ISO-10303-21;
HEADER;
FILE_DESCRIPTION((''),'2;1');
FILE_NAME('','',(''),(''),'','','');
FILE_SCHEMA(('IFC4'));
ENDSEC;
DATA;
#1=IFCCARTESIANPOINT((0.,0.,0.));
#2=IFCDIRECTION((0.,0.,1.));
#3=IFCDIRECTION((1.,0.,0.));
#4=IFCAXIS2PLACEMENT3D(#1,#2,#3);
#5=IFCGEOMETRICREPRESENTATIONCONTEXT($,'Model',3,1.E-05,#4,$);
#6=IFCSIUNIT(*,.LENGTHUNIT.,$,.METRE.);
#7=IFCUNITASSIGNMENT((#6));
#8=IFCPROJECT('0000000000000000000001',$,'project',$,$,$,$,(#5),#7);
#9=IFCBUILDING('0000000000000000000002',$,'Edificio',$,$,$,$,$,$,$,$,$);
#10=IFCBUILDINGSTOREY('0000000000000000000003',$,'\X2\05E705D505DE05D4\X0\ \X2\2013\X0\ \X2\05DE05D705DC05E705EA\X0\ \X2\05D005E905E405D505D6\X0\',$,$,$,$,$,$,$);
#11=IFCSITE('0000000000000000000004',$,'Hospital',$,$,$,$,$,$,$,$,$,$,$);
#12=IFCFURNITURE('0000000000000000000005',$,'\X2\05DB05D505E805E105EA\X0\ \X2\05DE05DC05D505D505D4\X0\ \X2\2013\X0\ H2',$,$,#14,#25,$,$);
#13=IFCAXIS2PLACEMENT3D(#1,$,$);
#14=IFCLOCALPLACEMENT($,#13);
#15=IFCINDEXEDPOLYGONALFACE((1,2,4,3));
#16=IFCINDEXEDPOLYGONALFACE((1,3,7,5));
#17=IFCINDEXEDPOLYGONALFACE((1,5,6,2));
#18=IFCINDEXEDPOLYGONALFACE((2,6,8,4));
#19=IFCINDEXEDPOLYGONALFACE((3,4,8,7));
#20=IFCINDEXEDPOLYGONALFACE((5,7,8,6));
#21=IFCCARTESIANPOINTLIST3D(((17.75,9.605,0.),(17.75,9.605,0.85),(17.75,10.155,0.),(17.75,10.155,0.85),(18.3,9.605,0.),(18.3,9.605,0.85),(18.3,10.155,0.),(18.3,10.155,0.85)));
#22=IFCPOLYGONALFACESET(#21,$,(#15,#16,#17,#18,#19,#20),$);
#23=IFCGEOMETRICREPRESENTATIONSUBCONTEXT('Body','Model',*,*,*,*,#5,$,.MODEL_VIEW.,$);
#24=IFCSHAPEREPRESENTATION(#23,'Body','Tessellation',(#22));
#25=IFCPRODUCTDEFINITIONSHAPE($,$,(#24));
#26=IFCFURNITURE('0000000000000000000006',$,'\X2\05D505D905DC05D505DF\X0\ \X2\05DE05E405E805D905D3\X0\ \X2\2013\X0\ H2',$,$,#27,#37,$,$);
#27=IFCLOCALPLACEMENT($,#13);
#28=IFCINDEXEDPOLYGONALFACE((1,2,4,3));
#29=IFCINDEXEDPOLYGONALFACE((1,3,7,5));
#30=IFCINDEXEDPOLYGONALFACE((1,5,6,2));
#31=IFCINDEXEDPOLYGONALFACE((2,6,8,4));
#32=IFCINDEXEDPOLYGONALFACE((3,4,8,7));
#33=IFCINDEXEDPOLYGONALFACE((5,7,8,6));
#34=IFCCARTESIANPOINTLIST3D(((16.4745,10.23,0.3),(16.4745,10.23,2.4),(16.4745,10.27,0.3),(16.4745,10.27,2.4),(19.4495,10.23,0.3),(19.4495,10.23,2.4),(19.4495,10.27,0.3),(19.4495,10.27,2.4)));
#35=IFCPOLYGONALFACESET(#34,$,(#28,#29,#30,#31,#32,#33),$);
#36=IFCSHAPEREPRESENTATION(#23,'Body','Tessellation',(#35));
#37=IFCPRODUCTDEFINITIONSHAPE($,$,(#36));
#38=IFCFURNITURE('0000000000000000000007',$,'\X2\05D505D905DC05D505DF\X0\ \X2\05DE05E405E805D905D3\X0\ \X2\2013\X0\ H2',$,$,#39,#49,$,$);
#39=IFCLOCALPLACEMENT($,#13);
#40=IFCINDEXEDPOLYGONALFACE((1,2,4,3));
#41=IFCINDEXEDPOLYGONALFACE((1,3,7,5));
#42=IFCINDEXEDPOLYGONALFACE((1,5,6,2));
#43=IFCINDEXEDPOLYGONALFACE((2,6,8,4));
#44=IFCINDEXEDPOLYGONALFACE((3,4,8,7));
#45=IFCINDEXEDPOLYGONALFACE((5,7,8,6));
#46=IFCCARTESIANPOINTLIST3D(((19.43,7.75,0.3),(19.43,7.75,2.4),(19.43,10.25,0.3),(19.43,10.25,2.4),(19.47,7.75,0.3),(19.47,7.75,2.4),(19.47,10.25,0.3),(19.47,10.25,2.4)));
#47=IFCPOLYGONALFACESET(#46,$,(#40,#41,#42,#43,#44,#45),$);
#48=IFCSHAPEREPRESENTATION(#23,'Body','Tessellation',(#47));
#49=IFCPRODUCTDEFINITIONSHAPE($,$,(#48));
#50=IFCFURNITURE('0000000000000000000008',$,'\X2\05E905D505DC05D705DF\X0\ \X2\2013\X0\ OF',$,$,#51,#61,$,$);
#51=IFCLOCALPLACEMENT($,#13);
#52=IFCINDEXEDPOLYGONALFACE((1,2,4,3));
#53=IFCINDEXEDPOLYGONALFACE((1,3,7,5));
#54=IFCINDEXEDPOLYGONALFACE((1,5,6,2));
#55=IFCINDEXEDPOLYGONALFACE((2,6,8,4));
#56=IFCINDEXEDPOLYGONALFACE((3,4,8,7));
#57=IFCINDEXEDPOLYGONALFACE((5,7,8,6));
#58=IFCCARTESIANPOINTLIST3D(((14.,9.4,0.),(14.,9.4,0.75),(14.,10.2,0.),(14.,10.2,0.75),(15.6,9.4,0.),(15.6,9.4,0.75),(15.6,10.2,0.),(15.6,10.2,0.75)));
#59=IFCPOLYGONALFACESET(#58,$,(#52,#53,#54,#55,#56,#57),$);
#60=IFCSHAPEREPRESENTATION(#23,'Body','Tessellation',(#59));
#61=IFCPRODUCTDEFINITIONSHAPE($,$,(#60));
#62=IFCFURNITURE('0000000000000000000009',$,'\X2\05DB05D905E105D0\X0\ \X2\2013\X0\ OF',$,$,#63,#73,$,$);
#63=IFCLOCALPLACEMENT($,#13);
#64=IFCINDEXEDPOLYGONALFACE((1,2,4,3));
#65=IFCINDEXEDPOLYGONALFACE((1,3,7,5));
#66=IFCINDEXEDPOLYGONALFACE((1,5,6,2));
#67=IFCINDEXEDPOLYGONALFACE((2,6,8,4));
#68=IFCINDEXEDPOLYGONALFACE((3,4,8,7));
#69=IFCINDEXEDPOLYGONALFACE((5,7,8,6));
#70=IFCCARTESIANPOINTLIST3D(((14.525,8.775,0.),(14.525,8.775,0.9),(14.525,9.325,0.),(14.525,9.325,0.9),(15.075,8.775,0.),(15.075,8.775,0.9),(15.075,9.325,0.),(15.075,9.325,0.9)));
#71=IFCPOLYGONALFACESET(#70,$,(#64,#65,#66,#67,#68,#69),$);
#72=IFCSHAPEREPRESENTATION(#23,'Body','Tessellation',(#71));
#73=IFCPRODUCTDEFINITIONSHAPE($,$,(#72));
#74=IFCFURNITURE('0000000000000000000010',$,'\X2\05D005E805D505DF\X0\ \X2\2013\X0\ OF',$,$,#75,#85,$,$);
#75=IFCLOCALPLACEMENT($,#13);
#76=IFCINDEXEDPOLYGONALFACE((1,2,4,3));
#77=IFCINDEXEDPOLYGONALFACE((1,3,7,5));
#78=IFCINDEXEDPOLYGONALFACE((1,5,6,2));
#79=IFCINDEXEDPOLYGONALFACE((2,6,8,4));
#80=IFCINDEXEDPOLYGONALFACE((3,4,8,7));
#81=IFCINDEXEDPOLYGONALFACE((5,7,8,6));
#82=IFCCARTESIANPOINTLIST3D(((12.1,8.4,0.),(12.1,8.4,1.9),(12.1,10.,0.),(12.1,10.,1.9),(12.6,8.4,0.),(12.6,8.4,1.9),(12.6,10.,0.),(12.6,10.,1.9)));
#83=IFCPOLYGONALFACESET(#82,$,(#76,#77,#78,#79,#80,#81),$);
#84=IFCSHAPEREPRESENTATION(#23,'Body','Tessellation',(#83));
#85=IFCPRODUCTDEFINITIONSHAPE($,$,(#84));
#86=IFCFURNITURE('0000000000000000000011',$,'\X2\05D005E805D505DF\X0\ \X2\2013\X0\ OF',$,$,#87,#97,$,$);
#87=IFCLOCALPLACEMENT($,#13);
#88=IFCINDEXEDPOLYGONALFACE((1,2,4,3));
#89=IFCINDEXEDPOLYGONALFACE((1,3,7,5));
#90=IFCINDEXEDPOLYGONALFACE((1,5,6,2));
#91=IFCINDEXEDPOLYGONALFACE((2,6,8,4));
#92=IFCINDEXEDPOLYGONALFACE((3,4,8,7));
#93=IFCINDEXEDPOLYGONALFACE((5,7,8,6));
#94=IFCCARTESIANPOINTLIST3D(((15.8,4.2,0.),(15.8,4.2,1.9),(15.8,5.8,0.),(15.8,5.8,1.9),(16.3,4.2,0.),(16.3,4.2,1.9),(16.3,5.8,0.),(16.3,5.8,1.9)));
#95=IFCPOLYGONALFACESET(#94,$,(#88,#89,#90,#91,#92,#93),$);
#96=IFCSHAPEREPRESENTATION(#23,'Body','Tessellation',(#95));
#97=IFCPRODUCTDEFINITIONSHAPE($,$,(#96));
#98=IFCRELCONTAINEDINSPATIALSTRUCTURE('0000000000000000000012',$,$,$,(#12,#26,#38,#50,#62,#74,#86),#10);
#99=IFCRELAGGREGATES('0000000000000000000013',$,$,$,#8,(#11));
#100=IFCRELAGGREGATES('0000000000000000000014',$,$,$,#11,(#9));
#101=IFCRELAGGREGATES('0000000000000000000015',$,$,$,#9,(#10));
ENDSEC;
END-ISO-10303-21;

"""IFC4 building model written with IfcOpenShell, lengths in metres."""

from ifc_helpers import new_model, si_unit, frame, origin_with_axes, context, subcontext, project, spatial, line, indexed_curve, outline, extrude, element, save


model = new_model("IFC4")

# Units and contexts
model_context = context("Model", 3, precision=1e-05, world=origin_with_axes())
body_context = subcontext(model_context, "Body", "Model", "MODEL_VIEW")
ifc_project = project(units=[si_unit("LENGTHUNIT", "METRE")], contexts=[model_context])

# Site, building, storey
site = spatial("IfcSite", under=ifc_project, Name="Hospital")
building = spatial("IfcBuilding", under=site, Name="Edificio")
storey = spatial("IfcBuildingStorey", under=building, Name="קומה – מחלקת אשפוז")

# Furniture
element("IfcFurniture", 1, inside=storey, Name="כורסת מלווה – H2", context=body_context, shape_type="SweptSolid", body=[
    extrude(outline(indexed_curve([(0.0, 0.0), (0.55, 0.0), (0.55, 0.55), (0.0, 0.55)], segments=[line(1, 2, 3, 4, 1)])), frame((17.75, 9.605, 0.0), z_axis=(0.0, 0.0, 1.0), x_axis=(1.0, 0.0, 0.0)), (0.0, 0.0, 1.0), 0.85),
])
element("IfcFurniture", 2, inside=storey, Name="וילון מפריד – H2", context=body_context, shape_type="SweptSolid", body=[
    extrude(outline(indexed_curve([(0.0, 0.0), (2.975, 0.0), (2.975, 0.04), (0.0, 0.04)], segments=[line(1, 2, 3, 4, 1)])), frame((16.4745, 10.23, 0.3), z_axis=(0.0, 0.0, 1.0), x_axis=(1.0, 0.0, 0.0)), (0.0, 0.0, 1.0), 2.1),
])
element("IfcFurniture", 3, inside=storey, Name="וילון מפריד – H2", context=body_context, shape_type="SweptSolid", body=[
    extrude(outline(indexed_curve([(0.0, 0.0), (0.04, 0.0), (0.04, 2.5), (0.0, 2.5)], segments=[line(1, 2, 3, 4, 1)])), frame((19.43, 7.75, 0.3), z_axis=(0.0, 0.0, 1.0), x_axis=(1.0, 0.0, 0.0)), (0.0, 0.0, 1.0), 2.1),
])
element("IfcFurniture", 4, inside=storey, Name="שולחן – OF", context=body_context, shape_type="SweptSolid", body=[
    extrude(outline(indexed_curve([(0.0, 0.0), (1.6, 0.0), (1.6, 0.8), (0.0, 0.8)], segments=[line(1, 2, 3, 4, 1)])), frame((14.0, 9.4, 0.0), z_axis=(0.0, 0.0, 1.0), x_axis=(1.0, 0.0, 0.0)), (0.0, 0.0, 1.0), 0.75),
])
element("IfcFurniture", 5, inside=storey, Name="כיסא – OF", context=body_context, shape_type="SweptSolid", body=[
    extrude(outline(indexed_curve([(0.0, 0.0), (0.55, 0.0), (0.55, 0.55), (0.0, 0.55)], segments=[line(1, 2, 3, 4, 1)])), frame((14.525, 8.775, 0.0), z_axis=(0.0, 0.0, 1.0), x_axis=(1.0, 0.0, 0.0)), (0.0, 0.0, 1.0), 0.9),
])
element("IfcFurniture", 6, inside=storey, Name="ארון – OF", context=body_context, shape_type="SweptSolid", body=[
    extrude(outline(indexed_curve([(0.0, 0.0), (0.5, 0.0), (0.5, 1.6), (0.0, 1.6)], segments=[line(1, 2, 3, 4, 1)])), frame((12.1, 8.4, 0.0), z_axis=(0.0, 0.0, 1.0), x_axis=(1.0, 0.0, 0.0)), (0.0, 0.0, 1.0), 1.9),
])
element("IfcFurniture", 7, inside=storey, Name="ארון – OF", context=body_context, shape_type="SweptSolid", body=[
    extrude(outline(indexed_curve([(0.0, 0.0), (0.5, 0.0), (0.5, 1.6), (0.0, 1.6)], segments=[line(1, 2, 3, 4, 1)])), frame((15.8, 4.2, 0.0), z_axis=(0.0, 0.0, 1.0), x_axis=(1.0, 0.0, 0.0)), (0.0, 0.0, 1.0), 1.9),
])

save(model, "model.ifc")
